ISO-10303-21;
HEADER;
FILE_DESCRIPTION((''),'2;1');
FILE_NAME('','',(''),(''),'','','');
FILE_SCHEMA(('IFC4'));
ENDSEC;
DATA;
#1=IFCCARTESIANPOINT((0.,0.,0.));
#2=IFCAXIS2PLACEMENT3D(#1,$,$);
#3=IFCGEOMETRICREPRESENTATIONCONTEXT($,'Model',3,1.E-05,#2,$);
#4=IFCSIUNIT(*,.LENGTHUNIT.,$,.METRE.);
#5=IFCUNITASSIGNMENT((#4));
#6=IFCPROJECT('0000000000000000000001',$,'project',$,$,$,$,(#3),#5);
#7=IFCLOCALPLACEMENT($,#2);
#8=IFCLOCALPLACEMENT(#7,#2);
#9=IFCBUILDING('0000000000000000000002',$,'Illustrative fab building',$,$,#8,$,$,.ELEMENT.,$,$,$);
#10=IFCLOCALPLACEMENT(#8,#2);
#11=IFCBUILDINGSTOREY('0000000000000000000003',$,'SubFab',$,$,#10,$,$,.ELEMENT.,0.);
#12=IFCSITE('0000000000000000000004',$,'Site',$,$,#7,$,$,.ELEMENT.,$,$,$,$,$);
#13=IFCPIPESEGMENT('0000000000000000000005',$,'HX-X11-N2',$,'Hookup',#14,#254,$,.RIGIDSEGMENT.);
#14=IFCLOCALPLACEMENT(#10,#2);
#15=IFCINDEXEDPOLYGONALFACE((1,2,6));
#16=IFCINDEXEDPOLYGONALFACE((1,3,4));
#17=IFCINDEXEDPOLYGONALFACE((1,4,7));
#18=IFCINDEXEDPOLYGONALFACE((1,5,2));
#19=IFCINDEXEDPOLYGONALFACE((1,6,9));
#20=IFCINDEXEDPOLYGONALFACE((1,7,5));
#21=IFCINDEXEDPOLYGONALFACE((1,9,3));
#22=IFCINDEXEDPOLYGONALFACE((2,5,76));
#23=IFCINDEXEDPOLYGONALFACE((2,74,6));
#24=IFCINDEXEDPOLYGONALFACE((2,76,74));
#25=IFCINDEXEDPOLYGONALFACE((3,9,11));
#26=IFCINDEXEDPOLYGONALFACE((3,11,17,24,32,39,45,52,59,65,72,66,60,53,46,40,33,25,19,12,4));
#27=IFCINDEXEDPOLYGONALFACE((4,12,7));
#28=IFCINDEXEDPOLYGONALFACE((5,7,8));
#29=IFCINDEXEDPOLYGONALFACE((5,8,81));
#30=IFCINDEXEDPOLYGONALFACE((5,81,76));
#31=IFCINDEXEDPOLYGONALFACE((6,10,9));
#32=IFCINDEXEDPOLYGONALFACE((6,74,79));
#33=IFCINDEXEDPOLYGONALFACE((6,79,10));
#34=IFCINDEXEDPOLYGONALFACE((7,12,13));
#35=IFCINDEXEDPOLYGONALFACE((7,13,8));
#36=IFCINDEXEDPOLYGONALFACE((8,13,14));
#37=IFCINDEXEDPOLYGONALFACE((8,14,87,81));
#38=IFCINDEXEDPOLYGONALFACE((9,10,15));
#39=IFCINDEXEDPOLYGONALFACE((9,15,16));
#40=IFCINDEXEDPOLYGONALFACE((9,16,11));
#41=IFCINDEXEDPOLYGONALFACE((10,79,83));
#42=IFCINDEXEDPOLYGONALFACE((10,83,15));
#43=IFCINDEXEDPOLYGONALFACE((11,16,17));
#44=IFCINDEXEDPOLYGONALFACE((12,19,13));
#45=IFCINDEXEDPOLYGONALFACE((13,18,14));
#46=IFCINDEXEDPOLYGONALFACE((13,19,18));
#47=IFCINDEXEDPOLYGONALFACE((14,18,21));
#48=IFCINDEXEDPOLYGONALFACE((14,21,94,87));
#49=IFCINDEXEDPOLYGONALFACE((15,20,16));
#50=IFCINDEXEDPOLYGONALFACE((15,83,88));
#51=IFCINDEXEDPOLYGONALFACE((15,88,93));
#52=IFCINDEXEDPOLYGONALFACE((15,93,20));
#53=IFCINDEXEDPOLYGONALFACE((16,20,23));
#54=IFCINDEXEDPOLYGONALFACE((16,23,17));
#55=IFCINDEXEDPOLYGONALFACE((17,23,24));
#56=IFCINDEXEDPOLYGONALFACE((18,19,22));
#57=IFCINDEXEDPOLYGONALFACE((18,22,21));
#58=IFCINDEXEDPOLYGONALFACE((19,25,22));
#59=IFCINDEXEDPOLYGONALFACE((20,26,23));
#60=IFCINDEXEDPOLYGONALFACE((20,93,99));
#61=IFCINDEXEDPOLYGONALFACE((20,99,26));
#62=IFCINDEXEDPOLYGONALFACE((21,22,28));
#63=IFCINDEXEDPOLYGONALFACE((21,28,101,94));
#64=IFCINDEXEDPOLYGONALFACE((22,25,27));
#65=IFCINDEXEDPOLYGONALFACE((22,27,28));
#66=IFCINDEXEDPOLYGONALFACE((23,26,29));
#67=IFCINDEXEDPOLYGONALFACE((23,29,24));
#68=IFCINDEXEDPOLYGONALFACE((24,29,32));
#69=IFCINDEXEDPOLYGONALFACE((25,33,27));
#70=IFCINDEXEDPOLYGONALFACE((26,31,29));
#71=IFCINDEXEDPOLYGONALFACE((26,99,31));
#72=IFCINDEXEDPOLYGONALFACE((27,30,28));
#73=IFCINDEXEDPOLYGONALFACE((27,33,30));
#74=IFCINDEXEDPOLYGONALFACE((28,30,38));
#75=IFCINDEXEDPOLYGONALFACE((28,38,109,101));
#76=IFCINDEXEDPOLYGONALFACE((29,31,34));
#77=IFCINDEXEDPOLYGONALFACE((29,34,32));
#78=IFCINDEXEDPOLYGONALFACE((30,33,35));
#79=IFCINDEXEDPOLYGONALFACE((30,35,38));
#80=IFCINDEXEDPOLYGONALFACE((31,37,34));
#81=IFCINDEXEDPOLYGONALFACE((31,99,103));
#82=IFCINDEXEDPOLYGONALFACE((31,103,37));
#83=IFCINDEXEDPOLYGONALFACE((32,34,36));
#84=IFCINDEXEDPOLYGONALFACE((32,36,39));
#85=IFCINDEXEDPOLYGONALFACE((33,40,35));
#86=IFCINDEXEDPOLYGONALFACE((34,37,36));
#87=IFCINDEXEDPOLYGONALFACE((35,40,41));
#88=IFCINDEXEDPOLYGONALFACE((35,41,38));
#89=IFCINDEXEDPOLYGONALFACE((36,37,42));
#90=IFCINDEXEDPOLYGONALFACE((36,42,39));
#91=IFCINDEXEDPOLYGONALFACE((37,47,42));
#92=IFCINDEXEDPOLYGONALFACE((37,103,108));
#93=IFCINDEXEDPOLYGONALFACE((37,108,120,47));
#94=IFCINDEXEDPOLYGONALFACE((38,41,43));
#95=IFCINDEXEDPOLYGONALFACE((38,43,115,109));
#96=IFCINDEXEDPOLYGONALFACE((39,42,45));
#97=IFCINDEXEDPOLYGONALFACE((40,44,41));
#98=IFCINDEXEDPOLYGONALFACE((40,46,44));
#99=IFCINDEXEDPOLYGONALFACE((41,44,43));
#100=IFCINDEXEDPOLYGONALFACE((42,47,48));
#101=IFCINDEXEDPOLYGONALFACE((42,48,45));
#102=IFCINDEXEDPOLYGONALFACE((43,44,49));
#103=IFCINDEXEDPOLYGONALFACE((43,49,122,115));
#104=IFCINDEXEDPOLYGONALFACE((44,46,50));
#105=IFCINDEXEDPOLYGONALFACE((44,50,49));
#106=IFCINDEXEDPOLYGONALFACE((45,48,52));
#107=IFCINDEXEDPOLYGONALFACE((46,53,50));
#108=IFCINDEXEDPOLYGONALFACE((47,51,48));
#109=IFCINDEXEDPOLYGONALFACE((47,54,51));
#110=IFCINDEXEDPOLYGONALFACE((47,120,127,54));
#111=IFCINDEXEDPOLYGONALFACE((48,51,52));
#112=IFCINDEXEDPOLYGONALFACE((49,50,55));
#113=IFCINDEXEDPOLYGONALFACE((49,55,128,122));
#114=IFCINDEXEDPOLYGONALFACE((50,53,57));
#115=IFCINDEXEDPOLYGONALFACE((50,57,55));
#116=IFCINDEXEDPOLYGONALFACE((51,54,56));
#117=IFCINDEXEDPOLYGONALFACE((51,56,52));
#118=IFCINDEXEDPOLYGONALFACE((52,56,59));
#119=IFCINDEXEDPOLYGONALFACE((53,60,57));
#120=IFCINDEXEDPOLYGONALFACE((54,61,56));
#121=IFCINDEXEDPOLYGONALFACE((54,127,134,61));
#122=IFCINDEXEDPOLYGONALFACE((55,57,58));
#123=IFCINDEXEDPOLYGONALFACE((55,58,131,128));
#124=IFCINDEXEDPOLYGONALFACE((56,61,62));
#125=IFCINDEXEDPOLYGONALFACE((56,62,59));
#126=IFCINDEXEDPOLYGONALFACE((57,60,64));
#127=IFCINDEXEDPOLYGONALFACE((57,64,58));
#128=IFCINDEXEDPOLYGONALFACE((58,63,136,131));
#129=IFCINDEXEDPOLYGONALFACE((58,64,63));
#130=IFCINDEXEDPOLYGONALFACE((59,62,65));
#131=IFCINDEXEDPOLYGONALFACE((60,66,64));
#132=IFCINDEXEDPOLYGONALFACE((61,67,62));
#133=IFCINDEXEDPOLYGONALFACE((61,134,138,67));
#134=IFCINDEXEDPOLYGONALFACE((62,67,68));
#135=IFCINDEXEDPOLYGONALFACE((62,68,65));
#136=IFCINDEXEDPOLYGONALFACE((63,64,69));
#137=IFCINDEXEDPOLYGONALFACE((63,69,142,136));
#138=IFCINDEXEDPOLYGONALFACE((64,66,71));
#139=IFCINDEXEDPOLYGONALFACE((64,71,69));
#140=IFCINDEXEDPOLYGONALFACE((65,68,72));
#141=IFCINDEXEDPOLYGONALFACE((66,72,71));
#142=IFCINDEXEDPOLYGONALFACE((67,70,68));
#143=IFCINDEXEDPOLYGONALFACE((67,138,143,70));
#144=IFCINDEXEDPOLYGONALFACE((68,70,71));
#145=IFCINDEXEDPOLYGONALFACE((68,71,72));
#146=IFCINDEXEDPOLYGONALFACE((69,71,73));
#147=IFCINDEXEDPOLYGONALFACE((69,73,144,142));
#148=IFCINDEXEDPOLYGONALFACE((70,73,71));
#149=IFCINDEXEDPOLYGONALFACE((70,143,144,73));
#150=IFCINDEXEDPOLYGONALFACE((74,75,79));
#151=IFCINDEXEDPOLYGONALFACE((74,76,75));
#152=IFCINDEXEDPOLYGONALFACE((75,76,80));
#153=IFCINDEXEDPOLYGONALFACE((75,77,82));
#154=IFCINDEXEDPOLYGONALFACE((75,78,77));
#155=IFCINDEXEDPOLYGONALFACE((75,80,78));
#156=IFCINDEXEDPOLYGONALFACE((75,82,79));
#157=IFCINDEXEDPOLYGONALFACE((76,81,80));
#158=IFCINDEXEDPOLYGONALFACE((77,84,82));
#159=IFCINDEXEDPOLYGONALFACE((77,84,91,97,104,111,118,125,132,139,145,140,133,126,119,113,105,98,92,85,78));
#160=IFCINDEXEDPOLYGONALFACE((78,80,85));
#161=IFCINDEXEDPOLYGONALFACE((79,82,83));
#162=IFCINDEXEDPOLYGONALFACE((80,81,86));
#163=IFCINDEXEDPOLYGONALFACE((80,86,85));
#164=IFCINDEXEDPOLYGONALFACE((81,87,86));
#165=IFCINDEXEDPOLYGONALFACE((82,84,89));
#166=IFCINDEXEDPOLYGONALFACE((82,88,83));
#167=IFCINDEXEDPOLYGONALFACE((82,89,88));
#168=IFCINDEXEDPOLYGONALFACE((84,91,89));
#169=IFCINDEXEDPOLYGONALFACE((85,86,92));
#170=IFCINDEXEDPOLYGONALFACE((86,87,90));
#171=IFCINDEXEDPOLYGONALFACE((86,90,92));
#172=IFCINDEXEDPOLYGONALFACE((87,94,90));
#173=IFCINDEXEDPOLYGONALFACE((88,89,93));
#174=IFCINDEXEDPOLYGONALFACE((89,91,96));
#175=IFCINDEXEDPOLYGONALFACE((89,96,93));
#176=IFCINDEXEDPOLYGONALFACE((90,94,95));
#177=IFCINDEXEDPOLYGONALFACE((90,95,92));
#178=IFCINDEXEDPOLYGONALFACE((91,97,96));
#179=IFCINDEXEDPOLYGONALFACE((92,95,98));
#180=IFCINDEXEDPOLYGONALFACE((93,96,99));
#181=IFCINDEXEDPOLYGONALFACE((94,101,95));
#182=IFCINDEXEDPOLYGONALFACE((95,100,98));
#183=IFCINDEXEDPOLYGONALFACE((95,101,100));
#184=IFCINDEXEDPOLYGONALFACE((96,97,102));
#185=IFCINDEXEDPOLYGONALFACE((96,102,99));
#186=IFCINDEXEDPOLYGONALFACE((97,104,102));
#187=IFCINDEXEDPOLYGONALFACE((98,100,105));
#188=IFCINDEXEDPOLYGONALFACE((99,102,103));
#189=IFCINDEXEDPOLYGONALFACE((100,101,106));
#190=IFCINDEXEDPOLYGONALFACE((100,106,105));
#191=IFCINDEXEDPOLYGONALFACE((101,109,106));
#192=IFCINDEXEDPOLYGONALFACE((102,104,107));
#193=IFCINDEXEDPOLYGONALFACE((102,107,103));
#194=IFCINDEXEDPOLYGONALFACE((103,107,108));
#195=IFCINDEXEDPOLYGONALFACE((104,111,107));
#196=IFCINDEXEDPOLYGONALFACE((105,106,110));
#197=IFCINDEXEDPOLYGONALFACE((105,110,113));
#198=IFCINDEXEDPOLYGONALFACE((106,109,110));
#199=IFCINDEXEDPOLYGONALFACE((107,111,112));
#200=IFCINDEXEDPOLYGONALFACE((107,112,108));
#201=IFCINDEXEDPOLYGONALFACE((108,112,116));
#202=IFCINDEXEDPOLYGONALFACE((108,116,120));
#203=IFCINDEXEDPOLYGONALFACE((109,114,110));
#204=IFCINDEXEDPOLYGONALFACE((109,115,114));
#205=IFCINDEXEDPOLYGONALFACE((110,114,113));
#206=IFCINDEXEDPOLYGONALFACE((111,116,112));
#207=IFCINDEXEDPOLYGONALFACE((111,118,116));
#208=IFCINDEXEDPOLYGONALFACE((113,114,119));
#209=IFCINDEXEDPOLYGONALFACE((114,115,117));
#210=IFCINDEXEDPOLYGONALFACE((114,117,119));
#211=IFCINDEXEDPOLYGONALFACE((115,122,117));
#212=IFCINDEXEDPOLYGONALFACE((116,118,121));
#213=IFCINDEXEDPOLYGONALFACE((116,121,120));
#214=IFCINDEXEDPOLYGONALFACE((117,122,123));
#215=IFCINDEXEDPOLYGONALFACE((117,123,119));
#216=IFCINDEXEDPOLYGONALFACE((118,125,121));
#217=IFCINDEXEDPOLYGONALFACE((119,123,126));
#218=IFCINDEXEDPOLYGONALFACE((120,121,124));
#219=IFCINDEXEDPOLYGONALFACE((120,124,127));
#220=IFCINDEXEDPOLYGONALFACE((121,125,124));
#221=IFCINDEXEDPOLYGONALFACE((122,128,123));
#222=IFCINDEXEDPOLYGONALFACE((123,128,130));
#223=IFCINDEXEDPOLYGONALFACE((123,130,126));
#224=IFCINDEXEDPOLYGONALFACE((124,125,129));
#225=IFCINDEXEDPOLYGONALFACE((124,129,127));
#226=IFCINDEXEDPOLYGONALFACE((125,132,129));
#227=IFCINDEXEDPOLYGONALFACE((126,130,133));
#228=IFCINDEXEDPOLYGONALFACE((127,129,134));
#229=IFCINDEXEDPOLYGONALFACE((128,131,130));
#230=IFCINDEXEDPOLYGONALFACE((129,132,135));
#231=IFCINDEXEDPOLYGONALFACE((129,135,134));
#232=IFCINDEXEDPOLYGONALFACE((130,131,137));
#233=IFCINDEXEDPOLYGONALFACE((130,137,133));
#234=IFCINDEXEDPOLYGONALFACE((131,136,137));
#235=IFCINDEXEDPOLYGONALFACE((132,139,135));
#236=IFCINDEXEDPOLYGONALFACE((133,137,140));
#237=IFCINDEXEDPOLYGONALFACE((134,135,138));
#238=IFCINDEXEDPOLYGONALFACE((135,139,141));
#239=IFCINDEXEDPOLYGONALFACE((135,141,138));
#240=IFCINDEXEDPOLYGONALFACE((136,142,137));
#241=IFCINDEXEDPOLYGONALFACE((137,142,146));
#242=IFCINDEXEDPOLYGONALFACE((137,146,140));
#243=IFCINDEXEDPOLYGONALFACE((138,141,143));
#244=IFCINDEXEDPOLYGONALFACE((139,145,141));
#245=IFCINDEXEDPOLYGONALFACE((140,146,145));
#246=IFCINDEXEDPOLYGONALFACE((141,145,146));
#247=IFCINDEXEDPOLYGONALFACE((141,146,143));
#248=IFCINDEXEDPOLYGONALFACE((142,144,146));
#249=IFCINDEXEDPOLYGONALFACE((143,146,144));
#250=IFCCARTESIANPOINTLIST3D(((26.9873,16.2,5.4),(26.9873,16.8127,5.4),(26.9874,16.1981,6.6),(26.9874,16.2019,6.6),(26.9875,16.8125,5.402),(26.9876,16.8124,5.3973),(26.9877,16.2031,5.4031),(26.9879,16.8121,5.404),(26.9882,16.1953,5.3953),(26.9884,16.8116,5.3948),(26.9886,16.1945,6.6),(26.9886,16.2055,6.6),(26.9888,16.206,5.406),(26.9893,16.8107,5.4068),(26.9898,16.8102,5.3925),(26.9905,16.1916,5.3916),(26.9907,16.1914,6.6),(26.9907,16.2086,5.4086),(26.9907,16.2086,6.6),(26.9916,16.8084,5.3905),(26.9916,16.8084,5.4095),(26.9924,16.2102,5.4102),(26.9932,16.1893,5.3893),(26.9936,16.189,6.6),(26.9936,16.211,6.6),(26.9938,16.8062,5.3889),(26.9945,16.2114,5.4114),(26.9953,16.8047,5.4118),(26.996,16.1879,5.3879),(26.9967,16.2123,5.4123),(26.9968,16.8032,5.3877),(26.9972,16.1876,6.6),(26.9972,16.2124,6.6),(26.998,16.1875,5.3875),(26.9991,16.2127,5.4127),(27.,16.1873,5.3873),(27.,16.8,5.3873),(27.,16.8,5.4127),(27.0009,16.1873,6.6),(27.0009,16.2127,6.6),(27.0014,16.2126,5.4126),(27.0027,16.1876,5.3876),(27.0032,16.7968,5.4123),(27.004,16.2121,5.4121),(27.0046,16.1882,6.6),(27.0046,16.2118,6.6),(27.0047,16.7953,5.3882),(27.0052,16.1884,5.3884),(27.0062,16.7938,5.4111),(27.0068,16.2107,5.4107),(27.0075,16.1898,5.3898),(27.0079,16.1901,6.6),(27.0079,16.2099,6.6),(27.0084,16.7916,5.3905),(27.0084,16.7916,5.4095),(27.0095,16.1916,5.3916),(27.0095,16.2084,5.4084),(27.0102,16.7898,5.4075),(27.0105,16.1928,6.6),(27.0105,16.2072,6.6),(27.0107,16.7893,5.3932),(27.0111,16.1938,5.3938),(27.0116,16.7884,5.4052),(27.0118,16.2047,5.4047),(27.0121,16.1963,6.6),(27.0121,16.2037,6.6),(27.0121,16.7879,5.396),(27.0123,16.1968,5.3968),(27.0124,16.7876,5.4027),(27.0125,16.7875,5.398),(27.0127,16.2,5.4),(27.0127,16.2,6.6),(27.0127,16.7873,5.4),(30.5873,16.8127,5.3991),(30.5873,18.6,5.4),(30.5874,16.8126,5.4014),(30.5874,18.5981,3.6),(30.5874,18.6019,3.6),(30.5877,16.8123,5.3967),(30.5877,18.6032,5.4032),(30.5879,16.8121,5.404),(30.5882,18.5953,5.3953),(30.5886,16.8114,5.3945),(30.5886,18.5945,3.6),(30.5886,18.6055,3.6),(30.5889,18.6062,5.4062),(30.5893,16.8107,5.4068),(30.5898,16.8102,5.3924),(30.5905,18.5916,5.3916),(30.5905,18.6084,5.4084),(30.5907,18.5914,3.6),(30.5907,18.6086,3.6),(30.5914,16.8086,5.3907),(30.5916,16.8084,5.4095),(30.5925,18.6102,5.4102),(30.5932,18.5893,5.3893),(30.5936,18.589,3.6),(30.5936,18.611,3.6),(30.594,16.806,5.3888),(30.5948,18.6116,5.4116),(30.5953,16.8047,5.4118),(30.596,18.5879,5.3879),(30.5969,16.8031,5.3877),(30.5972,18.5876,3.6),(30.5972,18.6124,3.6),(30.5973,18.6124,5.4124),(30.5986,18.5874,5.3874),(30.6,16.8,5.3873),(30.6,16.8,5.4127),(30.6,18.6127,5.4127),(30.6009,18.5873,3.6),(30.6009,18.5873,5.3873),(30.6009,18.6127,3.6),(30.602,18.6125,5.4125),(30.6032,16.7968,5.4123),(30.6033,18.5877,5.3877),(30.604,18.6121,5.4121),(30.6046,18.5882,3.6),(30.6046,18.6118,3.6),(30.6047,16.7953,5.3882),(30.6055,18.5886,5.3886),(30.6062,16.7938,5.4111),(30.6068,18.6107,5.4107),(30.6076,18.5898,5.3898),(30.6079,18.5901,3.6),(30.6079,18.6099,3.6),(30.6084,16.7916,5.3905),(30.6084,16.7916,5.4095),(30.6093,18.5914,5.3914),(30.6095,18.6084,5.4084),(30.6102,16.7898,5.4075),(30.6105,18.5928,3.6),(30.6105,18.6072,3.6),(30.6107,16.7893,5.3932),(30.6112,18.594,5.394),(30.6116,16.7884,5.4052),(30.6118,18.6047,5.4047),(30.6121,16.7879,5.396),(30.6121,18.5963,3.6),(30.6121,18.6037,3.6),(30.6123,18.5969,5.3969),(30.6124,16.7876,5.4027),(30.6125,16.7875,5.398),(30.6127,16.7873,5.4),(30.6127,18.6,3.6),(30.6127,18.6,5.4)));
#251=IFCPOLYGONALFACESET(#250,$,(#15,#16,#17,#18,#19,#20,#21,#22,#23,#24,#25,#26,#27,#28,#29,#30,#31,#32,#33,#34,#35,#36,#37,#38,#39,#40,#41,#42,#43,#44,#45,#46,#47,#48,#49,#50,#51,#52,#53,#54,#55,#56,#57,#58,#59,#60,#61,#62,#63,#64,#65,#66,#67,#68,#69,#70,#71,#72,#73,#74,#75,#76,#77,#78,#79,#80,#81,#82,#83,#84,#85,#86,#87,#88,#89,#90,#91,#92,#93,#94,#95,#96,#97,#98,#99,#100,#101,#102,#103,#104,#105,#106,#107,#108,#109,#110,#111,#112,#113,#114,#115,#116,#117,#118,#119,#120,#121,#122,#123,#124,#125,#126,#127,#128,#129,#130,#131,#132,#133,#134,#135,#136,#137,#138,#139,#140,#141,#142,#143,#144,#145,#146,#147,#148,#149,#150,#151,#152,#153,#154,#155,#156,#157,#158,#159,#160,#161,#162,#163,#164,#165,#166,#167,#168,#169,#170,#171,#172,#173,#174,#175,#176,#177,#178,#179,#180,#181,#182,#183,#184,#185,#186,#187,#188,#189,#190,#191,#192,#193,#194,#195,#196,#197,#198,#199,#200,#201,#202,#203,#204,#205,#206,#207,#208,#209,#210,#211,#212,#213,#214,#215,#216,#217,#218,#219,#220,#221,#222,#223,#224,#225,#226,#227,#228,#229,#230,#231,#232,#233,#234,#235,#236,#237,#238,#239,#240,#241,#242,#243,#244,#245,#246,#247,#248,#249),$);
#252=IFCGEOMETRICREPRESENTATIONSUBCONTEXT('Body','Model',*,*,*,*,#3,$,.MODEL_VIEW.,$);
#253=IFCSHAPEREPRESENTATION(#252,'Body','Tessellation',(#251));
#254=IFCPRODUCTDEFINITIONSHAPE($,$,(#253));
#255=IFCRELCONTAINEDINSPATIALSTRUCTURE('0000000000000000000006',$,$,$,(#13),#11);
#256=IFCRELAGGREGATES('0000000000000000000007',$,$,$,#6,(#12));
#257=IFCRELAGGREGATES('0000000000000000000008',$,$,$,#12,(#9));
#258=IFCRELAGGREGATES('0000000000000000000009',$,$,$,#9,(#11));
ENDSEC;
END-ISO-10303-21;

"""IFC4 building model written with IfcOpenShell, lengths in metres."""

from ifc_helpers import new_model, entity, si_unit, origin, place, context, subcontext, project, spatial, element, save


model = new_model("IFC4")

# Units and contexts
model_context = context("Model", 3, precision=1e-05, world=origin())
body_context = subcontext(model_context, "Body", "Model", "MODEL_VIEW")
ifc_project = project(units=[si_unit("LENGTHUNIT", "METRE")], contexts=[model_context])

# Site, building, storey
site_placement = place(None, origin())
site = spatial("IfcSite", under=ifc_project, at=site_placement, Name="Site", CompositionType="ELEMENT")
building_placement = place(site_placement, origin())
building = spatial("IfcBuilding", under=site, at=building_placement, Name="Illustrative fab building", CompositionType="ELEMENT")
storey_placement = place(building_placement, origin())
storey = spatial("IfcBuildingStorey", under=building, at=storey_placement, Name="SubFab", CompositionType="ELEMENT", Elevation=0.0)

# Pipe segment
pipe_segment_1_placement = place(storey_placement, origin())
element("IfcPipeSegment", 1, at=pipe_segment_1_placement, inside=storey, Name="HX-X11-N2", ObjectType="Hookup", PredefinedType="RIGIDSEGMENT", context=body_context, shape_type="AdvancedSweptSolid", body=[
    entity("IfcSweptDiskSolid", entity("IfcPolyline", [entity("IfcCartesianPoint", [30.6, 18.6, 3.6]), entity("IfcCartesianPoint", [30.6, 18.6, 5.4]), entity("IfcCartesianPoint", [30.6, 16.8, 5.4]), entity("IfcCartesianPoint", [27.0, 16.8, 5.4]), entity("IfcCartesianPoint", [27.0, 16.2, 5.4]), entity("IfcCartesianPoint", [27.0, 16.2, 6.6])]), 0.0127),
])

save(model, "model.ifc")
